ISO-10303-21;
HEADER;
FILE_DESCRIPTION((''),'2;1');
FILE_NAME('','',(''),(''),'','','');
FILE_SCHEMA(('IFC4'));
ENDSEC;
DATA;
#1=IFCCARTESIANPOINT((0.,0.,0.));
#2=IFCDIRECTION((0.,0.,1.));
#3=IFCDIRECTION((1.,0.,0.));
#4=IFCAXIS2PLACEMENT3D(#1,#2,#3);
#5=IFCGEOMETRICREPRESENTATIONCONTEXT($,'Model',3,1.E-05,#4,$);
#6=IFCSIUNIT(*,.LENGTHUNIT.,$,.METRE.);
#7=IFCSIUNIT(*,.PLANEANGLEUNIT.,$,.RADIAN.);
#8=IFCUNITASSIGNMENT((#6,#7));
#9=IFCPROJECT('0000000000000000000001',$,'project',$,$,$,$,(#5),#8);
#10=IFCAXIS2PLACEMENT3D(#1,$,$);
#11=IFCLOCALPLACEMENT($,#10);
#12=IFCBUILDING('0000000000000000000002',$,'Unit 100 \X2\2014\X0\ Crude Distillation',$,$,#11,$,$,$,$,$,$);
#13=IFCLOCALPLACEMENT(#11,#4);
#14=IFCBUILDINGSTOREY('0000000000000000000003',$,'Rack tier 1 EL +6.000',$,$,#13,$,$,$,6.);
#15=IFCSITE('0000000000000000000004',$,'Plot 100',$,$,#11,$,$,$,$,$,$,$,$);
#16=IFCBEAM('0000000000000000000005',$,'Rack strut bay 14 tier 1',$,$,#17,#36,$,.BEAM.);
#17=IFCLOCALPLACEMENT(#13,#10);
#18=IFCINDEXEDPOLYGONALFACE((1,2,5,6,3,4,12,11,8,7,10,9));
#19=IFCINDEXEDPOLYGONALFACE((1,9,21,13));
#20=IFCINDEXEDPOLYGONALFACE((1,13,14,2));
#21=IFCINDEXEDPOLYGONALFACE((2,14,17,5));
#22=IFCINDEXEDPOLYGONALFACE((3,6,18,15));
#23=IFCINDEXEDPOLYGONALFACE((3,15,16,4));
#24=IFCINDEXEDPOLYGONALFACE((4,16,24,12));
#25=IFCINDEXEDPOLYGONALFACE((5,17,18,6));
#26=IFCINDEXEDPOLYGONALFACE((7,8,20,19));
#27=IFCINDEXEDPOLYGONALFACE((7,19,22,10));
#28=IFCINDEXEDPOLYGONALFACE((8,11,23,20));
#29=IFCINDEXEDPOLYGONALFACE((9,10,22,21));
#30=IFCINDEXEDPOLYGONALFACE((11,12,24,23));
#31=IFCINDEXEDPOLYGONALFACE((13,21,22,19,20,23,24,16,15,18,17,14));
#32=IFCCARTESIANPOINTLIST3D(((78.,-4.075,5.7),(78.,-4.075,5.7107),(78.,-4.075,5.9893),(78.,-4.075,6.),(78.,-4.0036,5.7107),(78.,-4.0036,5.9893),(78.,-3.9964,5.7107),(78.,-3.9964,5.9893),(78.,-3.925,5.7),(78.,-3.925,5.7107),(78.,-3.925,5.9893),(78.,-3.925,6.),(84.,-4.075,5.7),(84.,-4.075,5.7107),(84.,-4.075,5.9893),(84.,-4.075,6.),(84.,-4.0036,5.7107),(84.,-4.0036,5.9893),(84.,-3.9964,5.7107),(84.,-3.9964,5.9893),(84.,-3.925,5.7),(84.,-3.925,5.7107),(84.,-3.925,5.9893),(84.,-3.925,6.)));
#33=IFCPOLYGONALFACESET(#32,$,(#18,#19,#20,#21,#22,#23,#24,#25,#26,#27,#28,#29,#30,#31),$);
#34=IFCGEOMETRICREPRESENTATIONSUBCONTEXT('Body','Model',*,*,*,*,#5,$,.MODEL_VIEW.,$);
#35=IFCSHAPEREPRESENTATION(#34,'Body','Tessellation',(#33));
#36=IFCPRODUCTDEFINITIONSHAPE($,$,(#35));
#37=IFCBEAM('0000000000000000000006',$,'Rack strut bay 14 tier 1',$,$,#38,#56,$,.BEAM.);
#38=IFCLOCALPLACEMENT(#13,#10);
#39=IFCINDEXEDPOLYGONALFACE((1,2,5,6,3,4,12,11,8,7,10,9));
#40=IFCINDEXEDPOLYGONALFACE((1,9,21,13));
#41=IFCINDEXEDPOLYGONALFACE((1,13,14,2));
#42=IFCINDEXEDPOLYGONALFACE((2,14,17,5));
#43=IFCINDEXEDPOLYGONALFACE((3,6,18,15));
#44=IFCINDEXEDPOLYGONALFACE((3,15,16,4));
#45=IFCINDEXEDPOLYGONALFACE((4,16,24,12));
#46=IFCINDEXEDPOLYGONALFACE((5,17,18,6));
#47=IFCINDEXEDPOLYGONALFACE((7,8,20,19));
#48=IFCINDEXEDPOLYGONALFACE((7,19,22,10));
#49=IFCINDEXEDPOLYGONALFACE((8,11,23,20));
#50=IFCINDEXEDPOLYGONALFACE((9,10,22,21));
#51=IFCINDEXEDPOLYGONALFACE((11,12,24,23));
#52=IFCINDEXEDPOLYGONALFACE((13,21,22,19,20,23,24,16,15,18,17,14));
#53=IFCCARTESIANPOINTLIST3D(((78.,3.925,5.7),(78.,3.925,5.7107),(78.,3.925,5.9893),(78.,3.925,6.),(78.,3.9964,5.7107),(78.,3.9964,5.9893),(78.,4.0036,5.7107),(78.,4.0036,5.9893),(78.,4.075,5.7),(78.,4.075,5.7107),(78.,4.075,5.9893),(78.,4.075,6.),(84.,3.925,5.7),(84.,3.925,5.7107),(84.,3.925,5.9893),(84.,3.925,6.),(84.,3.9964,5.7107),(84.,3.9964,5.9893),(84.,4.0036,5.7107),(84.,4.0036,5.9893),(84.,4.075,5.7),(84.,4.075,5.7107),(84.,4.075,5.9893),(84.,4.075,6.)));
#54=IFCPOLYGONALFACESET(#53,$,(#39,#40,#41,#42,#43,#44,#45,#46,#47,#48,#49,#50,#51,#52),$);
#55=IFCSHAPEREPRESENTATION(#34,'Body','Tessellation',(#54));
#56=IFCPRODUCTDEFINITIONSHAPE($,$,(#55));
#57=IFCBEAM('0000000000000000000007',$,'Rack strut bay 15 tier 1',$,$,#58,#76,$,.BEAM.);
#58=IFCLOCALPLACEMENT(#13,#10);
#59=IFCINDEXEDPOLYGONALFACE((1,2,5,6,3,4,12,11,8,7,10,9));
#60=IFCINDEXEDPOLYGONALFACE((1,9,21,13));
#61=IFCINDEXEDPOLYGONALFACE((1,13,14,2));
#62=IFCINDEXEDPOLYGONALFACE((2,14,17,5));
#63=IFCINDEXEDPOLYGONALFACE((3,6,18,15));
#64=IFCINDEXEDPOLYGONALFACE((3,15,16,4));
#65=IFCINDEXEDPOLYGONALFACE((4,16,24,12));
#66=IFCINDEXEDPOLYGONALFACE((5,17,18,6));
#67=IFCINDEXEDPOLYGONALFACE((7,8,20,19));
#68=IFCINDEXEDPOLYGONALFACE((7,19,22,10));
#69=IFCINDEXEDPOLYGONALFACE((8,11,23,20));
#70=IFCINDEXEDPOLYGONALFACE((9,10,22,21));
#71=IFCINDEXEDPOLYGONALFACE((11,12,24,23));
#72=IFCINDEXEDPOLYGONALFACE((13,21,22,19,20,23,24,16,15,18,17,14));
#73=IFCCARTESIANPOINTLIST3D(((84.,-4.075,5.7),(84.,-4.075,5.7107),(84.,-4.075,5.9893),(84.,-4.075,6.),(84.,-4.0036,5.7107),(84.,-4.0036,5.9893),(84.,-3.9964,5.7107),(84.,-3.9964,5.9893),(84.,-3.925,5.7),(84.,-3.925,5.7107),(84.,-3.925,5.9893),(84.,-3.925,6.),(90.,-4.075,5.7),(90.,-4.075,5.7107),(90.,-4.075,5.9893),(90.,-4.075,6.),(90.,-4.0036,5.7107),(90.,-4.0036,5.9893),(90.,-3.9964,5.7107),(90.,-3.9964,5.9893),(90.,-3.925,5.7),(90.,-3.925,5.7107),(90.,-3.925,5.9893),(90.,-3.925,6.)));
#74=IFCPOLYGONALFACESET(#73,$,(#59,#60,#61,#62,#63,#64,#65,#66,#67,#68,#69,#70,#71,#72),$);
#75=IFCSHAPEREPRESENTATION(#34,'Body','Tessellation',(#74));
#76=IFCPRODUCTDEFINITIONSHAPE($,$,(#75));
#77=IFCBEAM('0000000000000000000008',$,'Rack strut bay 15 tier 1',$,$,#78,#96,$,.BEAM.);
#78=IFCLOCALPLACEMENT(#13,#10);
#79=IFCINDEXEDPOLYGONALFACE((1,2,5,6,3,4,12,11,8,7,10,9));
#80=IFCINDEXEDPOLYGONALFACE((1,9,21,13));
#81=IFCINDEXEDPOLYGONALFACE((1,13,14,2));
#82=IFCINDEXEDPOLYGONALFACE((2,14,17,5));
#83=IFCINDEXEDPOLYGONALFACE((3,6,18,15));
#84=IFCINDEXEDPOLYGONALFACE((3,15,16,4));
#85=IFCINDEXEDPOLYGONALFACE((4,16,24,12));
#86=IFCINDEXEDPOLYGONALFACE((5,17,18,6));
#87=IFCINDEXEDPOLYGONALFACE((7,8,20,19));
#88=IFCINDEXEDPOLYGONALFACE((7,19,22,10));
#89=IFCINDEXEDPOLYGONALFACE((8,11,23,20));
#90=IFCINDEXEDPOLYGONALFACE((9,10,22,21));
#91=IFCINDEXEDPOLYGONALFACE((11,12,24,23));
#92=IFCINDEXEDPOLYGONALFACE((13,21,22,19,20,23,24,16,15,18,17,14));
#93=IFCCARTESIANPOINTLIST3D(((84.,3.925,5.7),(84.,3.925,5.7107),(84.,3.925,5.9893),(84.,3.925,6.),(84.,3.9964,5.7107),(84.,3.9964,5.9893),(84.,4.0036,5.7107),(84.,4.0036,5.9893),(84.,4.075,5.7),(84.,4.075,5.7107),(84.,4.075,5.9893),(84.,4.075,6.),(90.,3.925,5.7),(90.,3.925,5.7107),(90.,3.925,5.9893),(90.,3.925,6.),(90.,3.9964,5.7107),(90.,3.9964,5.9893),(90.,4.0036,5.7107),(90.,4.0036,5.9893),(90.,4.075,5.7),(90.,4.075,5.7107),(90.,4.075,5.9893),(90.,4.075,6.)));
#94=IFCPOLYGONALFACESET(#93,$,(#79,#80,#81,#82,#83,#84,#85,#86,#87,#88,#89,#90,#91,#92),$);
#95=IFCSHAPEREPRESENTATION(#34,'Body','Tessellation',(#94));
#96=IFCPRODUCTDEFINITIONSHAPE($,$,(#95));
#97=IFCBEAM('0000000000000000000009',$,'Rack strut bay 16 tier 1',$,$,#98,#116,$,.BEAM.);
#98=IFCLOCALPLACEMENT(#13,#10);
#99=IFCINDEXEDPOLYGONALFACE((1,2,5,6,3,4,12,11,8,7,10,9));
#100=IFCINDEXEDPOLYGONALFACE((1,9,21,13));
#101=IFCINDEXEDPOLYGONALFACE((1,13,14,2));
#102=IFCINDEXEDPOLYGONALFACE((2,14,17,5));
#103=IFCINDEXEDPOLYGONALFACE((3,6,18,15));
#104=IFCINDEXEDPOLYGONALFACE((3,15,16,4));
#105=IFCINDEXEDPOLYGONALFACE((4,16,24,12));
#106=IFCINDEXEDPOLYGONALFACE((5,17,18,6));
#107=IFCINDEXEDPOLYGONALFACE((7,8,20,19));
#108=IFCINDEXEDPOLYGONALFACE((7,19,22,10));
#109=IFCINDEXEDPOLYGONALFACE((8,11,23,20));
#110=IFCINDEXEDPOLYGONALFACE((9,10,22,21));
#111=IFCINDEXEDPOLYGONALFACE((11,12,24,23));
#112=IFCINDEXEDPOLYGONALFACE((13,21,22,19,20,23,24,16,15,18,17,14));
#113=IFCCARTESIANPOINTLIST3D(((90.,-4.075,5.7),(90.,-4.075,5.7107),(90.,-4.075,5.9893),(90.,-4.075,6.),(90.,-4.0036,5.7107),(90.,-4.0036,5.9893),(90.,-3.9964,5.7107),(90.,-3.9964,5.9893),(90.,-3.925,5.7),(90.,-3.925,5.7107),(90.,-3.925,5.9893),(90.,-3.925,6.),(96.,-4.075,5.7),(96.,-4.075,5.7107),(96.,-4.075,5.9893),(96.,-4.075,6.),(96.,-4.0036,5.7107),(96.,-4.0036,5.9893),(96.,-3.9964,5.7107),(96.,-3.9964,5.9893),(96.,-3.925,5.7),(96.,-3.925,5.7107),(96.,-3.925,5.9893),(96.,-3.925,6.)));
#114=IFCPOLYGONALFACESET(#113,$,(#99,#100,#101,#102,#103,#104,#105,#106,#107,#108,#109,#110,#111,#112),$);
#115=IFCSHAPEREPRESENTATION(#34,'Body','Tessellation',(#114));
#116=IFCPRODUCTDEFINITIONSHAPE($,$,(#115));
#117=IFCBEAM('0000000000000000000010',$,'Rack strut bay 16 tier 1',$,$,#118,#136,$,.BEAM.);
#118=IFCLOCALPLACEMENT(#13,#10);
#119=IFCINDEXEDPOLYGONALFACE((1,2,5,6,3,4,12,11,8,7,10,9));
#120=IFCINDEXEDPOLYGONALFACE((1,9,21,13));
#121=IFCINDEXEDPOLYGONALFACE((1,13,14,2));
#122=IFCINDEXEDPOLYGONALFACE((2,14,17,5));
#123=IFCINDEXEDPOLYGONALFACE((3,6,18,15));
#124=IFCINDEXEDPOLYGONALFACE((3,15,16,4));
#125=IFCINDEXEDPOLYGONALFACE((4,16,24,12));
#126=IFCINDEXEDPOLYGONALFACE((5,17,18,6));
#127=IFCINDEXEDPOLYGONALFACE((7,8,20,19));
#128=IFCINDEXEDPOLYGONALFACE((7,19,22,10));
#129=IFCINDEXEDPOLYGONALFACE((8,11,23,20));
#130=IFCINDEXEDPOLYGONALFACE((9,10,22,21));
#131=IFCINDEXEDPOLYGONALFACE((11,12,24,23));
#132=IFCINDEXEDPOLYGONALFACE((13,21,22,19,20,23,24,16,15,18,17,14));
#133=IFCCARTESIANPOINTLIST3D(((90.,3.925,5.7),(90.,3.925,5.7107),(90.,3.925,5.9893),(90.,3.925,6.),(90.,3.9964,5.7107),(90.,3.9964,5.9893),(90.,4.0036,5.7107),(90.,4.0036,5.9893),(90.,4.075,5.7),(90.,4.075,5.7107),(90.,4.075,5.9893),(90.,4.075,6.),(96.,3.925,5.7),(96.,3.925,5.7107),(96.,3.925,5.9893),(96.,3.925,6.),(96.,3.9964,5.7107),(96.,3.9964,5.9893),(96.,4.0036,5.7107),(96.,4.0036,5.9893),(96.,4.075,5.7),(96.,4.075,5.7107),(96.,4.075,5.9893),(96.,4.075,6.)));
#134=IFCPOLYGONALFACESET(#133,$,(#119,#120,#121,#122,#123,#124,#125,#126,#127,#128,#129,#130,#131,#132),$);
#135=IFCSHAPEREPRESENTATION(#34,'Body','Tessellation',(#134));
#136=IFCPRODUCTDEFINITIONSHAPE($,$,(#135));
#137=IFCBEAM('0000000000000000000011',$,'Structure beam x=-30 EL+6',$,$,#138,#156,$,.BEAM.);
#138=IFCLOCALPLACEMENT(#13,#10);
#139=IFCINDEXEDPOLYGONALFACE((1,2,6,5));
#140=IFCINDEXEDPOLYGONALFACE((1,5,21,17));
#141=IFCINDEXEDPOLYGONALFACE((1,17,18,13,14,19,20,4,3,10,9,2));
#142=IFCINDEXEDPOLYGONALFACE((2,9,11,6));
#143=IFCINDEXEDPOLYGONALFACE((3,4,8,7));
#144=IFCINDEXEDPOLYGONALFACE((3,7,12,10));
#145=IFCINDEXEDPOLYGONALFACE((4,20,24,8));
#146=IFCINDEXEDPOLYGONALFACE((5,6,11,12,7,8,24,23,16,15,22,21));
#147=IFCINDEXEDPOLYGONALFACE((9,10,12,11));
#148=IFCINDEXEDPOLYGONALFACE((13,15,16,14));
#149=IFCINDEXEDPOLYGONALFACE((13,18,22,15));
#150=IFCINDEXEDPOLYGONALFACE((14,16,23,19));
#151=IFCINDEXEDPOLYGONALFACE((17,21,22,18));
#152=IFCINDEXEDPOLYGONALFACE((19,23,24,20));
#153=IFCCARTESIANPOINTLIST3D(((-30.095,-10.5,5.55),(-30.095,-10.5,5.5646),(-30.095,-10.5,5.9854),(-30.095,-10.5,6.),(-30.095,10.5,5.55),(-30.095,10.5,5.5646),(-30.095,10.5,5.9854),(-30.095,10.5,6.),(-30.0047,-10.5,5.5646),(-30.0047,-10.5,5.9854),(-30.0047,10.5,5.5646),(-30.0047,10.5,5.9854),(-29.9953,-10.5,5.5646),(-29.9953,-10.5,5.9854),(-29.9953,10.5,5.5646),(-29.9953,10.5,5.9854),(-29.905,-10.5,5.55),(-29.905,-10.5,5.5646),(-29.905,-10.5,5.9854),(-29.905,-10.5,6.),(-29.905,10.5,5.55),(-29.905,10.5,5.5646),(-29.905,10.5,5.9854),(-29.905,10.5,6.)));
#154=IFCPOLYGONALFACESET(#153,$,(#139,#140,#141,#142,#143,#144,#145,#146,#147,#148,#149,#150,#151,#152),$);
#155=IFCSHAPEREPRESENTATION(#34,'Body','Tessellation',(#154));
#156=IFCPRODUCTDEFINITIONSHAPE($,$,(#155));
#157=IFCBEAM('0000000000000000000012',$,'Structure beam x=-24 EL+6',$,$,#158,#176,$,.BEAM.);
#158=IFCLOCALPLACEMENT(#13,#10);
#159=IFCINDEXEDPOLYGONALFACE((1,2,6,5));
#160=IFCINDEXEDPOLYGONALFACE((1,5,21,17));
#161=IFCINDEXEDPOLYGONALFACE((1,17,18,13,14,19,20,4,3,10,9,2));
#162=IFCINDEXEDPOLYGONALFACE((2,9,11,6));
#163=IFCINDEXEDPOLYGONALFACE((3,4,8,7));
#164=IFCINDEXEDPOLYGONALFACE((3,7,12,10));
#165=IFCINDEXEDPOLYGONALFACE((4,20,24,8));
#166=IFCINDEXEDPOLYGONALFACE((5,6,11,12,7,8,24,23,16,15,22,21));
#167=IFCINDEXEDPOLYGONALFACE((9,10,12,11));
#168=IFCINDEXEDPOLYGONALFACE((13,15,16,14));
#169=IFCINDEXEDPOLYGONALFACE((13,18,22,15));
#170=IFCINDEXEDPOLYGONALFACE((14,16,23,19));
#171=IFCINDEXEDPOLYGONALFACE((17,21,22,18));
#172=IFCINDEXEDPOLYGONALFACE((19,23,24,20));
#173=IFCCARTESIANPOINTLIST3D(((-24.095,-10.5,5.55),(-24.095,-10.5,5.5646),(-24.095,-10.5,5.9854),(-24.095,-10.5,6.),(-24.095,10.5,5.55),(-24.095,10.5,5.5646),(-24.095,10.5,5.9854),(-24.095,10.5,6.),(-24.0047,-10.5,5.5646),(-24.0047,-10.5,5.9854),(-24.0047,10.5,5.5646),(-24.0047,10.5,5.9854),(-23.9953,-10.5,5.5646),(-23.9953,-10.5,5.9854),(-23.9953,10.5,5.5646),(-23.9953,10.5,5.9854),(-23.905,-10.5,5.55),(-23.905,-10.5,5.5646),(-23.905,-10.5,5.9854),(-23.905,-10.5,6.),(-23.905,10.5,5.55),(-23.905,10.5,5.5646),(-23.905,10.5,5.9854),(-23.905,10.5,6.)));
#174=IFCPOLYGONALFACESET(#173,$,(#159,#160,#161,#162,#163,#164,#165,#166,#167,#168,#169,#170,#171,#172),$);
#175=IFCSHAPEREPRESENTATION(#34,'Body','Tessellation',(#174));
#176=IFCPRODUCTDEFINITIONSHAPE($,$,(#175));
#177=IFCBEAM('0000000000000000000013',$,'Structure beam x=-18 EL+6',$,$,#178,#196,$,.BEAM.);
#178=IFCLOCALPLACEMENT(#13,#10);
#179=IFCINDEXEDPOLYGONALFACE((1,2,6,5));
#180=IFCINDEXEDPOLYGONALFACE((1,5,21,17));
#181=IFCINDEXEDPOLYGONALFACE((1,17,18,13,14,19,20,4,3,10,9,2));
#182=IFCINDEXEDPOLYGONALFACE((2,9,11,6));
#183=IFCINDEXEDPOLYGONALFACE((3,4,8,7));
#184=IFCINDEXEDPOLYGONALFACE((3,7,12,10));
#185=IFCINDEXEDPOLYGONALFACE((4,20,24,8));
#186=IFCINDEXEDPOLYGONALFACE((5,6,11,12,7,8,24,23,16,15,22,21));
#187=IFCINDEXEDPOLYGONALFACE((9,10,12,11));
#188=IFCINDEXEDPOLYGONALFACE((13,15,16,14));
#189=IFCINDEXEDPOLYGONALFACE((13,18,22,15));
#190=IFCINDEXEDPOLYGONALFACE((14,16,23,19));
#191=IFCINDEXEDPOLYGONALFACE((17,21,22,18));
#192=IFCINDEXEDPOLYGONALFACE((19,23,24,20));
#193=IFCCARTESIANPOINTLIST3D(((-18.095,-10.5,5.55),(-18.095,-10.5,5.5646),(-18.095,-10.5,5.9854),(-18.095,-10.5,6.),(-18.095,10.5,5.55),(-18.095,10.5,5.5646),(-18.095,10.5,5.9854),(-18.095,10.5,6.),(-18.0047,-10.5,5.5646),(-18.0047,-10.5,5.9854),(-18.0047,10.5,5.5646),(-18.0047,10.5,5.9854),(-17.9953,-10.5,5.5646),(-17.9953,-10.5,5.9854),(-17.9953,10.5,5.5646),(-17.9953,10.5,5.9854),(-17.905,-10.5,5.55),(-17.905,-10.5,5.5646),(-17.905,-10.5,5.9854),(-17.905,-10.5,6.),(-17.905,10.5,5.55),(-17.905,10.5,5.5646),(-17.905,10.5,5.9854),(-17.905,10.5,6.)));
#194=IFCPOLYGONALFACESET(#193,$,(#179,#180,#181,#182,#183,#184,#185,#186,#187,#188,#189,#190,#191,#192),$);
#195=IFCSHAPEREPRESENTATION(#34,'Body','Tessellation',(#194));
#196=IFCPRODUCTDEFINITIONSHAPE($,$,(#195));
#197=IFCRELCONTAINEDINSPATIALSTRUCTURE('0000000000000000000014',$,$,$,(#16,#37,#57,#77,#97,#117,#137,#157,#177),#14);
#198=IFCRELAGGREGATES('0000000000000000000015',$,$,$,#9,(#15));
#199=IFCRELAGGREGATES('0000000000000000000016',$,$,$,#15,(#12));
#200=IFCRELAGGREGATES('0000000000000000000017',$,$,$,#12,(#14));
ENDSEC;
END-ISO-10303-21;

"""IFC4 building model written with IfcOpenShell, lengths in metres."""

from ifc_helpers import new_model, si_unit, frame, origin, origin_with_axes, origin_2d, place, context, subcontext, project, spatial, i_section, extrude, element, save


model = new_model("IFC4")

# Units and contexts
model_context = context("Model", 3, precision=1e-05, world=origin_with_axes())
body_context = subcontext(model_context, "Body", "Model", "MODEL_VIEW")
ifc_project = project(units=[si_unit("LENGTHUNIT", "METRE"), si_unit("PLANEANGLEUNIT", "RADIAN")], contexts=[model_context])

# Site, building, storey
placement = place(None, origin())
site = spatial("IfcSite", under=ifc_project, at=placement, Name="Plot 100")
building = spatial("IfcBuilding", under=site, at=placement, Name="Unit 100 — Crude Distillation")
storey_placement = place(placement, origin_with_axes())
storey = spatial("IfcBuildingStorey", under=building, at=storey_placement, Name="Rack tier 1 EL +6.000", Elevation=6.0)

# Beams
beam_1_placement = place(storey_placement, origin_with_axes())
element("IfcBeam", 1, at=beam_1_placement, inside=storey, Name="Rack strut bay 14 tier 1", PredefinedType="BEAM", context=body_context, shape_type="SweptSolid", body=[
    extrude(i_section(OverallWidth=0.15, OverallDepth=0.3, WebThickness=0.0071, FlangeThickness=0.0107, at=origin_2d()), frame((78.0, -4.0, 5.85), z_axis=(1.0, 0.0, 0.0), x_axis=(0.0, 1.0, 0.0)), (0.0, 0.0, 1.0), 6.0),
])
beam_2_placement = place(storey_placement, origin_with_axes())
element("IfcBeam", 2, at=beam_2_placement, inside=storey, Name="Rack strut bay 14 tier 1", PredefinedType="BEAM", context=body_context, shape_type="SweptSolid", body=[
    extrude(i_section(OverallWidth=0.15, OverallDepth=0.3, WebThickness=0.0071, FlangeThickness=0.0107, at=origin_2d()), frame((78.0, 4.0, 5.85), z_axis=(1.0, 0.0, 0.0), x_axis=(0.0, 1.0, 0.0)), (0.0, 0.0, 1.0), 6.0),
])
beam_3_placement = place(storey_placement, origin_with_axes())
element("IfcBeam", 3, at=beam_3_placement, inside=storey, Name="Rack strut bay 15 tier 1", PredefinedType="BEAM", context=body_context, shape_type="SweptSolid", body=[
    extrude(i_section(OverallWidth=0.15, OverallDepth=0.3, WebThickness=0.0071, FlangeThickness=0.0107, at=origin_2d()), frame((84.0, -4.0, 5.85), z_axis=(1.0, 0.0, 0.0), x_axis=(0.0, 1.0, 0.0)), (0.0, 0.0, 1.0), 6.0),
])
beam_4_placement = place(storey_placement, origin_with_axes())
element("IfcBeam", 4, at=beam_4_placement, inside=storey, Name="Rack strut bay 15 tier 1", PredefinedType="BEAM", context=body_context, shape_type="SweptSolid", body=[
    extrude(i_section(OverallWidth=0.15, OverallDepth=0.3, WebThickness=0.0071, FlangeThickness=0.0107, at=origin_2d()), frame((84.0, 4.0, 5.85), z_axis=(1.0, 0.0, 0.0), x_axis=(0.0, 1.0, 0.0)), (0.0, 0.0, 1.0), 6.0),
])
beam_5_placement = place(storey_placement, origin_with_axes())
element("IfcBeam", 5, at=beam_5_placement, inside=storey, Name="Rack strut bay 16 tier 1", PredefinedType="BEAM", context=body_context, shape_type="SweptSolid", body=[
    extrude(i_section(OverallWidth=0.15, OverallDepth=0.3, WebThickness=0.0071, FlangeThickness=0.0107, at=origin_2d()), frame((90.0, -4.0, 5.85), z_axis=(1.0, 0.0, 0.0), x_axis=(0.0, 1.0, 0.0)), (0.0, 0.0, 1.0), 6.0),
])
beam_6_placement = place(storey_placement, origin_with_axes())
element("IfcBeam", 6, at=beam_6_placement, inside=storey, Name="Rack strut bay 16 tier 1", PredefinedType="BEAM", context=body_context, shape_type="SweptSolid", body=[
    extrude(i_section(OverallWidth=0.15, OverallDepth=0.3, WebThickness=0.0071, FlangeThickness=0.0107, at=origin_2d()), frame((90.0, 4.0, 5.85), z_axis=(1.0, 0.0, 0.0), x_axis=(0.0, 1.0, 0.0)), (0.0, 0.0, 1.0), 6.0),
])
beam_7_placement = place(storey_placement, origin_with_axes())
element("IfcBeam", 7, at=beam_7_placement, inside=storey, Name="Structure beam x=-30 EL+6", PredefinedType="BEAM", context=body_context, shape_type="SweptSolid", body=[
    extrude(i_section(OverallWidth=0.19, OverallDepth=0.45, WebThickness=0.0094, FlangeThickness=0.0146, at=origin_2d()), frame((-30.0, -10.5, 5.775), z_axis=(0.0, 1.0, 0.0), x_axis=(-1.0, 0.0, 0.0)), (0.0, 0.0, 1.0), 21.0),
])
beam_8_placement = place(storey_placement, origin_with_axes())
element("IfcBeam", 8, at=beam_8_placement, inside=storey, Name="Structure beam x=-24 EL+6", PredefinedType="BEAM", context=body_context, shape_type="SweptSolid", body=[
    extrude(i_section(OverallWidth=0.19, OverallDepth=0.45, WebThickness=0.0094, FlangeThickness=0.0146, at=origin_2d()), frame((-24.0, -10.5, 5.775), z_axis=(0.0, 1.0, 0.0), x_axis=(-1.0, 0.0, 0.0)), (0.0, 0.0, 1.0), 21.0),
])
beam_9_placement = place(storey_placement, origin_with_axes())
element("IfcBeam", 9, at=beam_9_placement, inside=storey, Name="Structure beam x=-18 EL+6", PredefinedType="BEAM", context=body_context, shape_type="SweptSolid", body=[
    extrude(i_section(OverallWidth=0.19, OverallDepth=0.45, WebThickness=0.0094, FlangeThickness=0.0146, at=origin_2d()), frame((-18.0, -10.5, 5.775), z_axis=(0.0, 1.0, 0.0), x_axis=(-1.0, 0.0, 0.0)), (0.0, 0.0, 1.0), 21.0),
])

save(model, "model.ifc")
